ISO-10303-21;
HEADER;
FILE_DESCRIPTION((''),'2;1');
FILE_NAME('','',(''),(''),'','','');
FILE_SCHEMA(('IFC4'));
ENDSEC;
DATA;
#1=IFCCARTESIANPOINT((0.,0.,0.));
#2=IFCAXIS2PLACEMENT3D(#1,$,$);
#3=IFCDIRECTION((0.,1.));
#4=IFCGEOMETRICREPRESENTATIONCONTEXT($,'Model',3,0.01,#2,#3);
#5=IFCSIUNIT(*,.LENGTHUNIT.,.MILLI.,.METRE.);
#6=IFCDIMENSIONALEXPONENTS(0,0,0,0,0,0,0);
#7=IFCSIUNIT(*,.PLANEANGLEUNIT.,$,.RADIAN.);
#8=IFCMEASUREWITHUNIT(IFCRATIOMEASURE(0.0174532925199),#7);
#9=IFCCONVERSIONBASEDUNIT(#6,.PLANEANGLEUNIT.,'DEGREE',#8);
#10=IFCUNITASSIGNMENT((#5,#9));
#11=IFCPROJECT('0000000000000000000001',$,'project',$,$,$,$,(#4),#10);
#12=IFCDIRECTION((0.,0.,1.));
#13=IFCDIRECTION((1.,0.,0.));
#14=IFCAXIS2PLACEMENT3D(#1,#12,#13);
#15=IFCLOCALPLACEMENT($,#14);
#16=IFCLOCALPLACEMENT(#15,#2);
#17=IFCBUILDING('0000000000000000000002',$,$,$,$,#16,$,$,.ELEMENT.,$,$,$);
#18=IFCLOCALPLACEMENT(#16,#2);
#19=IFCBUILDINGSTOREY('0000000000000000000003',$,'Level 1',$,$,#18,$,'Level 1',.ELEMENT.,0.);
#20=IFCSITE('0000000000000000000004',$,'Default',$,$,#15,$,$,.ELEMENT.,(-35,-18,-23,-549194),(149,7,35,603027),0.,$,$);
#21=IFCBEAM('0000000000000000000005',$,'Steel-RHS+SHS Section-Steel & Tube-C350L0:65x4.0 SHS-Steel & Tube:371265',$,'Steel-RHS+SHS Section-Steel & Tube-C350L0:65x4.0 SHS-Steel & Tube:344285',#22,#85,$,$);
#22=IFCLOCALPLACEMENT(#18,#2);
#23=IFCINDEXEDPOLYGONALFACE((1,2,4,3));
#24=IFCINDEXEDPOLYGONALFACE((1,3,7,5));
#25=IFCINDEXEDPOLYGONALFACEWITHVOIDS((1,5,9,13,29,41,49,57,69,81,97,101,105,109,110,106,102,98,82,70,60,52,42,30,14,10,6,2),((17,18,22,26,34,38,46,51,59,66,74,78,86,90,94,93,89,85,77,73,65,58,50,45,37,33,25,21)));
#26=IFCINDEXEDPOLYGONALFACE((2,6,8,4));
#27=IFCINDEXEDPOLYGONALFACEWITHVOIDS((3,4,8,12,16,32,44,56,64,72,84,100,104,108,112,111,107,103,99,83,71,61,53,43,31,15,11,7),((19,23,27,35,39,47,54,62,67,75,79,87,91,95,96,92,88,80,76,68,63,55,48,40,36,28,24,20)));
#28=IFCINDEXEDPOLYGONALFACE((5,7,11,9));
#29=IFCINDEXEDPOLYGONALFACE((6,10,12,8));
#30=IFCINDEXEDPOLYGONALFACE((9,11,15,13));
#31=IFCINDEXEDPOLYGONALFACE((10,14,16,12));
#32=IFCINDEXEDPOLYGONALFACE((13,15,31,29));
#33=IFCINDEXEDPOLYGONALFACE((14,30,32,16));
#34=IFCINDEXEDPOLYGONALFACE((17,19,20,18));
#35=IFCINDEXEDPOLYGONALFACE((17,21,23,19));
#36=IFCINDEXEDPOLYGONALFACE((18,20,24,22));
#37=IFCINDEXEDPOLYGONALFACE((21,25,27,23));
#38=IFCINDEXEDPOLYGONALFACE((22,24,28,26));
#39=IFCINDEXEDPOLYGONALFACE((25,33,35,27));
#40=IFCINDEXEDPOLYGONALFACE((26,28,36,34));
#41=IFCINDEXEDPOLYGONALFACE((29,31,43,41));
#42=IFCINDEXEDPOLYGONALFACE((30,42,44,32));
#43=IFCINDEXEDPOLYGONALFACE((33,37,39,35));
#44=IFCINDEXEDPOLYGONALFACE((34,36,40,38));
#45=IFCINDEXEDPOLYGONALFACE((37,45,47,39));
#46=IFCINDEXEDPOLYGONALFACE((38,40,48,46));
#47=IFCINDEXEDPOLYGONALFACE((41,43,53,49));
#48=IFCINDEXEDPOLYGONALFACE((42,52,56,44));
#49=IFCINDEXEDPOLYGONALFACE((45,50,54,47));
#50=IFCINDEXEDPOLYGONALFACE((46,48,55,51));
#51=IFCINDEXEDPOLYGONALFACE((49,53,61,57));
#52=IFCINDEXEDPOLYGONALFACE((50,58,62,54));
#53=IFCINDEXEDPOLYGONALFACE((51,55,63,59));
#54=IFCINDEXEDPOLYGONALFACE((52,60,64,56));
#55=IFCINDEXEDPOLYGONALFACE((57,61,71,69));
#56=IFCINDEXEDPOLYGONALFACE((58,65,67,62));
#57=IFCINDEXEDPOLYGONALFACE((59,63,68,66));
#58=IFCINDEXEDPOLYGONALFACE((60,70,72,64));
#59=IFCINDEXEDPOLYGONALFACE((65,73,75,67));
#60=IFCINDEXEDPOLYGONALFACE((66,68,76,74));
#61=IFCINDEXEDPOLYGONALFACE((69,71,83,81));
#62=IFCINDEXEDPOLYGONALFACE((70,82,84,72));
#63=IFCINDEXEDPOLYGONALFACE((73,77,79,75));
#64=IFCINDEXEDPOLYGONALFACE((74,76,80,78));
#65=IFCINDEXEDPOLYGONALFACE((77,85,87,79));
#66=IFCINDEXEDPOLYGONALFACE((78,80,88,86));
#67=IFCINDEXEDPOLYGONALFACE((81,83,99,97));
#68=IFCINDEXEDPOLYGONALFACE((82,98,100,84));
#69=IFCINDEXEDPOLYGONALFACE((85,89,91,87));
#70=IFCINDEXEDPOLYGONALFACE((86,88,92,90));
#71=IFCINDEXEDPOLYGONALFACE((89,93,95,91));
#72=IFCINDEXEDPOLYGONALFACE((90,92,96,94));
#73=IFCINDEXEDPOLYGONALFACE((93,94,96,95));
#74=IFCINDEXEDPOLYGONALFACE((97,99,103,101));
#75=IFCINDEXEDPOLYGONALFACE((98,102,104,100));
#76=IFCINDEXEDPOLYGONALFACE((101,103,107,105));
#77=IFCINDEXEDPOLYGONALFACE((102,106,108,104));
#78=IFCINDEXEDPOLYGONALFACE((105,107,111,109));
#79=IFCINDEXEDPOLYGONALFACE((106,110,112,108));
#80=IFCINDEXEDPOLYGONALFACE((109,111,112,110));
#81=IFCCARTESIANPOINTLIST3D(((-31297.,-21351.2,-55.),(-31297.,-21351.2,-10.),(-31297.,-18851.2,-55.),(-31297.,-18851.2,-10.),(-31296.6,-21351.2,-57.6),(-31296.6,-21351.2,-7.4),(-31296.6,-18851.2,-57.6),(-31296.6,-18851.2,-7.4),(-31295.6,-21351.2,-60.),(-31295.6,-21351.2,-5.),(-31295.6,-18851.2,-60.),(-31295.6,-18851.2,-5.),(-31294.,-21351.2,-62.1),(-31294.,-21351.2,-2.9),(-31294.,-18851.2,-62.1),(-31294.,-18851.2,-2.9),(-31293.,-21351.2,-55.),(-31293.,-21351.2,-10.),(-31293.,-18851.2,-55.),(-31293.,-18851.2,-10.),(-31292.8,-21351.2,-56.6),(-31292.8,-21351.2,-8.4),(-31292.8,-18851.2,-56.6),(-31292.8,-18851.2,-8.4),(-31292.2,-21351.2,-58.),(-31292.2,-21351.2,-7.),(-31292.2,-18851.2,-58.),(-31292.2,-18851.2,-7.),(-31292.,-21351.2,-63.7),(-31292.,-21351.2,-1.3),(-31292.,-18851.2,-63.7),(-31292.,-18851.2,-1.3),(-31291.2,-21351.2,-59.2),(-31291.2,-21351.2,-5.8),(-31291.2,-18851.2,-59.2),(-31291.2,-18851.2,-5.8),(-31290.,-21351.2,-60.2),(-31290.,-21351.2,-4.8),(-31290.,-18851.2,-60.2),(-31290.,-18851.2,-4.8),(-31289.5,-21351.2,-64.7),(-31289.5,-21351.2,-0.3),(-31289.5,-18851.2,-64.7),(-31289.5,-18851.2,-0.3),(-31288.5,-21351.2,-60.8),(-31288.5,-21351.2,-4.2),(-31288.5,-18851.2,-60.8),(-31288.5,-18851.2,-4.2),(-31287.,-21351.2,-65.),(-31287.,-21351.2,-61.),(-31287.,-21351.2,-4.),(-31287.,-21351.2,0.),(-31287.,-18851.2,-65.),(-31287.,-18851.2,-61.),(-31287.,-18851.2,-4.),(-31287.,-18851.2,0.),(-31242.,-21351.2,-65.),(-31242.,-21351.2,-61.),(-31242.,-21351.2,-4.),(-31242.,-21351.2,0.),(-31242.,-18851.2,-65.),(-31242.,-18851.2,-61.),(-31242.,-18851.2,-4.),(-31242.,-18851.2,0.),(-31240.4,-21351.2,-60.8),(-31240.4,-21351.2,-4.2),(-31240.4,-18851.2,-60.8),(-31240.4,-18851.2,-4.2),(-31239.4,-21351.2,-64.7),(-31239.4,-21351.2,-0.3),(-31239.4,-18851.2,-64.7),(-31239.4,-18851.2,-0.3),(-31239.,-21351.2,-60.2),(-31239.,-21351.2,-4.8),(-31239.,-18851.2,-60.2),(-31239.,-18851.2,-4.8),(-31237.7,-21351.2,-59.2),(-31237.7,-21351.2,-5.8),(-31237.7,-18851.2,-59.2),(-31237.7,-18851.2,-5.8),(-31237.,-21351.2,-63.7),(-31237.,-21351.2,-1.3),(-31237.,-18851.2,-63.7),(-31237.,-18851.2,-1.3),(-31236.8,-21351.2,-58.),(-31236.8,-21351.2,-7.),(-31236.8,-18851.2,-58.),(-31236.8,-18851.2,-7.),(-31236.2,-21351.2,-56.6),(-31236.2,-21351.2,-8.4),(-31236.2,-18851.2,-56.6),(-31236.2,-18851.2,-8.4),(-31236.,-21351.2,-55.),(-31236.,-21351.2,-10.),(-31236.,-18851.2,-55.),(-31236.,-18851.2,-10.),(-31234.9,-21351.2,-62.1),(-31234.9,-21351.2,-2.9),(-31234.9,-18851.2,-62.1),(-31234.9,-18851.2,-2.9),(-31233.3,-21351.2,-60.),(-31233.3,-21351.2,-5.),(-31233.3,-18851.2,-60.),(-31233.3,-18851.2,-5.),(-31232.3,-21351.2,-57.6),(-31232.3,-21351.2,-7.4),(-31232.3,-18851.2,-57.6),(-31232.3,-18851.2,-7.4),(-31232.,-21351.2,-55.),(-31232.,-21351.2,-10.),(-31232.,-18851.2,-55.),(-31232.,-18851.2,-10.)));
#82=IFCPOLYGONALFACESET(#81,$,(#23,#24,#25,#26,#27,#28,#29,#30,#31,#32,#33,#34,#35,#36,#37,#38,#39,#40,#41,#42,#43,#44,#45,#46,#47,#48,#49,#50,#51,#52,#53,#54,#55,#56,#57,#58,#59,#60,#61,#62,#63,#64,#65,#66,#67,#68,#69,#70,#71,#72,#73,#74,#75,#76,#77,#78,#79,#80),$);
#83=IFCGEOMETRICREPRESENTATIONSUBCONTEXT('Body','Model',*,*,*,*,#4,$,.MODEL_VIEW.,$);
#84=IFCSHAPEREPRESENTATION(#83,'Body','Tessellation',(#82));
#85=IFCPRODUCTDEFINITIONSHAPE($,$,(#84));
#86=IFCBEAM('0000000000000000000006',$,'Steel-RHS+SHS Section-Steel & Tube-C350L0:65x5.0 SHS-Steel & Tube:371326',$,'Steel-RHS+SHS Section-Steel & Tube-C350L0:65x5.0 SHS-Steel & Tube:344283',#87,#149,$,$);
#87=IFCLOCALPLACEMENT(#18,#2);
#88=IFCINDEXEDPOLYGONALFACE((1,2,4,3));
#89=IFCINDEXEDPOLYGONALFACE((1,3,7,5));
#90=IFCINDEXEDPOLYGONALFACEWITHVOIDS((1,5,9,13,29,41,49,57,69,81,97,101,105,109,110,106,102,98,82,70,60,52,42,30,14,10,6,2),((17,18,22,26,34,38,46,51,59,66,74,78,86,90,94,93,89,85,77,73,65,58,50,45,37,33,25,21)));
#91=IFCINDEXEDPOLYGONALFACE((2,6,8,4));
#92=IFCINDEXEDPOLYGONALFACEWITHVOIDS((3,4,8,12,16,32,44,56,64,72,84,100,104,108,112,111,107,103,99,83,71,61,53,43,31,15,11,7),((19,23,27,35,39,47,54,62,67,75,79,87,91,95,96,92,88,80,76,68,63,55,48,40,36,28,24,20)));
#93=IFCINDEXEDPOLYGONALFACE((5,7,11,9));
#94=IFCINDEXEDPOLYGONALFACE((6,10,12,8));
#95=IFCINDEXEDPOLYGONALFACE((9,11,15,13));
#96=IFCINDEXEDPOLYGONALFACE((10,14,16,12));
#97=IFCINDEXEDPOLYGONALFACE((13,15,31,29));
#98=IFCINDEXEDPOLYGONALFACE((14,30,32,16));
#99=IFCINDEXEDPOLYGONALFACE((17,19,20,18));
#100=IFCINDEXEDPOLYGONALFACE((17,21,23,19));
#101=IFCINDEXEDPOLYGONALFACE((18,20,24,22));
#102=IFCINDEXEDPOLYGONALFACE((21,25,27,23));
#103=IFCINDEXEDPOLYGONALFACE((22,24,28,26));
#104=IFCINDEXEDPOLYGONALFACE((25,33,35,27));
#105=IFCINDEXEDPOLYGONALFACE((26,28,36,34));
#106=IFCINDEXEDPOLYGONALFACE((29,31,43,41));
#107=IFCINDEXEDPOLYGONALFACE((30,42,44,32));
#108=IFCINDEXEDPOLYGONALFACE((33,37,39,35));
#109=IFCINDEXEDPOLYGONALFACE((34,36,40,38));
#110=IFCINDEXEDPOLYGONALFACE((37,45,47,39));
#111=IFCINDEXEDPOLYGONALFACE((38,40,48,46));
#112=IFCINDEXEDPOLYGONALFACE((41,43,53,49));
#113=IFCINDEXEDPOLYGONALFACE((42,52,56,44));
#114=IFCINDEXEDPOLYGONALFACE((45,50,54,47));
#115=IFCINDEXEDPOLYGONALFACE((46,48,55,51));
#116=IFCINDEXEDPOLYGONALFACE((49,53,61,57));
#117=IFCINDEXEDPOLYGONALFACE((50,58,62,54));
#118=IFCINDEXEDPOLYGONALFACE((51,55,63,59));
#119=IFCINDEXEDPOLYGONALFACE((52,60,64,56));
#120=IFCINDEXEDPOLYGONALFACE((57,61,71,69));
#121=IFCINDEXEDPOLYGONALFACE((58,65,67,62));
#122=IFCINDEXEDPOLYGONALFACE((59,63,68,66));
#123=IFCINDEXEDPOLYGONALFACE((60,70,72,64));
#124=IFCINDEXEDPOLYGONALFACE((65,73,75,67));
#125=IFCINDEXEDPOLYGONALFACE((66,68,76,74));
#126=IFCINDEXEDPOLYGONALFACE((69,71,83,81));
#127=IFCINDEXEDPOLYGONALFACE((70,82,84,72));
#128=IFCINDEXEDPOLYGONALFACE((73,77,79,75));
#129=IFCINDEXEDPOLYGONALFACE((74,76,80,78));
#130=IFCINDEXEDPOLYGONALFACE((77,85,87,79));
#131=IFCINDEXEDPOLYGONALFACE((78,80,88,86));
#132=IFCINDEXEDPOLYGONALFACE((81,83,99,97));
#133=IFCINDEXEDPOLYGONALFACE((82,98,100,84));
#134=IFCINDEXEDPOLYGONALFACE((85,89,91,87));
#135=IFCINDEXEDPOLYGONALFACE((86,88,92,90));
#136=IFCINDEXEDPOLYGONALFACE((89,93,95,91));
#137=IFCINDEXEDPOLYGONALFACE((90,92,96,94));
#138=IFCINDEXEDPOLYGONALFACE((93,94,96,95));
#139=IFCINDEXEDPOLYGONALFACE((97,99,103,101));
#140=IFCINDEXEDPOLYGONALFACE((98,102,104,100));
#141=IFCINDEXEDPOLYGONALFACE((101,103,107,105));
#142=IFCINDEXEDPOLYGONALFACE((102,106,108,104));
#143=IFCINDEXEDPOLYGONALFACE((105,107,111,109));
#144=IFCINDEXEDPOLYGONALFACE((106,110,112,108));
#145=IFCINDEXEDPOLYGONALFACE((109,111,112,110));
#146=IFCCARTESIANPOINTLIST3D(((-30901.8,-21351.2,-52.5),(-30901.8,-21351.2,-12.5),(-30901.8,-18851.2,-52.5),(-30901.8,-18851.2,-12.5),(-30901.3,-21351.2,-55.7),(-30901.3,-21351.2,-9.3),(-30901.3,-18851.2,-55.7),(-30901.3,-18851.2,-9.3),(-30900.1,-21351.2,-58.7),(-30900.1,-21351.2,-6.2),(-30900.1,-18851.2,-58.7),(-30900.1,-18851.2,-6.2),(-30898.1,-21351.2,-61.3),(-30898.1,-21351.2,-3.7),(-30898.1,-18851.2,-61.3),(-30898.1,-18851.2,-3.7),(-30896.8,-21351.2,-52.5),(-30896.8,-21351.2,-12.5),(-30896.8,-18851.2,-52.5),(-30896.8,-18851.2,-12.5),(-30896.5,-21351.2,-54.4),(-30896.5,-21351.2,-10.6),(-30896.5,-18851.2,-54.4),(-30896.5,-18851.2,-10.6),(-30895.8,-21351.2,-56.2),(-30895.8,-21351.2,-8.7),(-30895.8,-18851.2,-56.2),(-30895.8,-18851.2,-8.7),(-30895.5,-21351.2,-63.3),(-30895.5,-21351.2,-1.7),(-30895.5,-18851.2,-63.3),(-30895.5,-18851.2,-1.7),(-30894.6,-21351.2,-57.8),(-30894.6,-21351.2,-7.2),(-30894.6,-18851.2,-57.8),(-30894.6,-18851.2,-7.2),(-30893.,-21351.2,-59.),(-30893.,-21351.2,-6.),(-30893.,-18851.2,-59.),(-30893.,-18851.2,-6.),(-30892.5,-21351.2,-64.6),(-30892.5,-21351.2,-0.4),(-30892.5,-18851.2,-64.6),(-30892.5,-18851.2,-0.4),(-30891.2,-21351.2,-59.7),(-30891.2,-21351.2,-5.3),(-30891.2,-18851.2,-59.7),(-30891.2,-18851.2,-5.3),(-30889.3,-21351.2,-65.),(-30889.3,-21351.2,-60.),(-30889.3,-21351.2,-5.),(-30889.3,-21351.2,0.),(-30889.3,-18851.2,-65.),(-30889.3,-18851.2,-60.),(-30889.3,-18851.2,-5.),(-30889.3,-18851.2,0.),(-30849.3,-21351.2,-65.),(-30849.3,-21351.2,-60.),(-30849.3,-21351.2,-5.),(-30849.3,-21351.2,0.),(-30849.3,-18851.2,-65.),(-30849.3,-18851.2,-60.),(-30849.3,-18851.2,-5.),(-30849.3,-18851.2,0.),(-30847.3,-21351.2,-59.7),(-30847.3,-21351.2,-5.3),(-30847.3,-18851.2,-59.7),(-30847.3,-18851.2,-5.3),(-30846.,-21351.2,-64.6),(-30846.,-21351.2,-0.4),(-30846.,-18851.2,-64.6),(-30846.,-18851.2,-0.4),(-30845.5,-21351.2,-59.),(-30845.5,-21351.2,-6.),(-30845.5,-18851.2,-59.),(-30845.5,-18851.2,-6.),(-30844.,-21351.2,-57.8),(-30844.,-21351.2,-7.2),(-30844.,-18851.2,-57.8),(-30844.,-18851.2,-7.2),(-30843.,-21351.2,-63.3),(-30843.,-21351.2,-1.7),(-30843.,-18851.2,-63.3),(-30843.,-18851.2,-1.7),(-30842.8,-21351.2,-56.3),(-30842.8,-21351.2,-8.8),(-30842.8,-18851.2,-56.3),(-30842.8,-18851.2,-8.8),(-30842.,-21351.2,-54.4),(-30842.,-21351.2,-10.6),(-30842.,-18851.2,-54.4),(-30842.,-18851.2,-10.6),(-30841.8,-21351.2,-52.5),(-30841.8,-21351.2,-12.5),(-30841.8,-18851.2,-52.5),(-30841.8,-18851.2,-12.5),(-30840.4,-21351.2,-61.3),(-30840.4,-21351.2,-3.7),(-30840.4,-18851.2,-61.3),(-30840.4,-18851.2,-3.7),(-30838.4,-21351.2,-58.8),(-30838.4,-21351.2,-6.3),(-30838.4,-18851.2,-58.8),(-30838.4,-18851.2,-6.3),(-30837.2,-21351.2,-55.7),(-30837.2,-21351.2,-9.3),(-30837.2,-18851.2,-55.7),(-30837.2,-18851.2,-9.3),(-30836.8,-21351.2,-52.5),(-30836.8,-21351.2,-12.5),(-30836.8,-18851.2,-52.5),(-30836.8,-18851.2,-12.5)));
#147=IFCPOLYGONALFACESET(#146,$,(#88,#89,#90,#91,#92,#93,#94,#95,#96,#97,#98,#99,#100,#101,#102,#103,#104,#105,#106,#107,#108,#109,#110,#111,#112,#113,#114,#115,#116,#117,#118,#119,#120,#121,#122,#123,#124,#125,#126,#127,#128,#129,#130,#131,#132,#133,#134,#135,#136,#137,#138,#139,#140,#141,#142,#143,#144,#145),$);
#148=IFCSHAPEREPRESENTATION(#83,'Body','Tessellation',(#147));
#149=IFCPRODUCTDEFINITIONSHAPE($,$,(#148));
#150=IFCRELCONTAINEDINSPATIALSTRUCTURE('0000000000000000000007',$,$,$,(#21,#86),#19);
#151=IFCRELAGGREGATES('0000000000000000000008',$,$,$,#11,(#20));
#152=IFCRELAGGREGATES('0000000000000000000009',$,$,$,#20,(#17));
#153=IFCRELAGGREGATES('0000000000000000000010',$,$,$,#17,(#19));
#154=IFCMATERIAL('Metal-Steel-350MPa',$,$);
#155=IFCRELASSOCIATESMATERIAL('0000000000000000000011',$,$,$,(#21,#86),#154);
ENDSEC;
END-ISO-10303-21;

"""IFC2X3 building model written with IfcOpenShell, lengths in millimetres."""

from ifc_helpers import new_model, entity, si_unit, converted_unit, direction, frame, frame_2d, origin, origin_with_axes, place, context, subcontext, project, spatial, polyline, circle_curve, parameter, trimmed, segment, composite_curve, outline, extrude, material, element, save


model = new_model("IFC2X3")

# Units and contexts
model_context = context("Model", 3, precision=0.01, world=origin(), true_north=direction((0.0, 1.0)))
body_context = subcontext(model_context, "Body", "Model", "MODEL_VIEW")
ifc_project = project(units=[si_unit("LENGTHUNIT", "METRE", prefix="MILLI"), converted_unit("PLANEANGLEUNIT", "DEGREE", entity("IfcRatioMeasure", 0.0174532925199), si_unit("PLANEANGLEUNIT", "RADIAN"), dimensions=[0, 0, 0, 0, 0, 0, 0])], contexts=[model_context])

# Site, building, storey
site_placement = place(None, origin_with_axes())
site = spatial("IfcSite", under=ifc_project, at=site_placement, Name="Default", CompositionType="ELEMENT", RefLatitude=(-35, -18, -23, -549194), RefLongitude=(149, 7, 35, 603027), RefElevation=0.0)
building_placement = place(site_placement, origin())
building = spatial("IfcBuilding", under=site, at=building_placement, CompositionType="ELEMENT")
storey_placement = place(building_placement, origin())
storey = spatial("IfcBuildingStorey", under=building, at=storey_placement, Name="Level 1", LongName="Level 1", CompositionType="ELEMENT", Elevation=0.0)

# Beams
ifc_material = material(Name="Metal-Steel-350MPa")
beam_1_placement = place(storey_placement, frame((-31264.5, -18851.2, 0.0), z_axis=(0.0, 0.0, 1.0), x_axis=(0.0, -1.0, 0.0)))
element("IfcBeam", 1, at=beam_1_placement, inside=storey, material=ifc_material, Name="Steel-RHS+SHS Section-Steel & Tube-C350L0:65x4.0 SHS-Steel & Tube:371265", ObjectType="Steel-RHS+SHS Section-Steel & Tube-C350L0:65x4.0 SHS-Steel & Tube:344285", context=body_context, shape_type="SweptSolid", body=[
    extrude(outline(composite_curve([segment(trimmed(circle_curve(frame_2d((-22.5, -22.5), x_axis=(1.0, 0.0)), 10.0), [parameter(180.0)], [parameter(270.0)], True, "PARAMETER"), True, "CONTINUOUS"), segment(polyline([(-22.5, -32.5), (22.5, -32.5)]), True, "CONTINUOUS"), segment(trimmed(circle_curve(frame_2d((22.5, -22.5), x_axis=(1.0, 0.0)), 10.0), [parameter(270.0)], [parameter(0.0)], True, "PARAMETER"), True, "CONTINUOUS"), segment(polyline([(32.5, -22.5), (32.5, 22.5)]), True, "CONTINUOUS"), segment(trimmed(circle_curve(frame_2d((22.5, 22.5), x_axis=(1.0, 0.0)), 10.0), [parameter(0.0)], [parameter(90.0)], True, "PARAMETER"), True, "CONTINUOUS"), segment(polyline([(22.5, 32.5), (-22.5, 32.5)]), True, "CONTINUOUS"), segment(trimmed(circle_curve(frame_2d((-22.5, 22.5), x_axis=(1.0, 0.0)), 10.0), [parameter(90.0)], [parameter(180.0)], True, "PARAMETER"), True, "CONTINUOUS"), segment(polyline([(-32.5, 22.5), (-32.5, -22.5)]), True, "CONTINUOUS")], self_intersect=False), holes=[composite_curve([segment(polyline([(22.5, -28.5), (-22.5, -28.5)]), True, "CONTINUOUS"), segment(trimmed(circle_curve(frame_2d((-22.5, -22.5), x_axis=(1.0, 0.0)), 6.0), [parameter(180.0)], [parameter(270.0)], True, "PARAMETER"), False, "CONTINUOUS"), segment(polyline([(-28.5, -22.5), (-28.5, 22.5)]), True, "CONTINUOUS"), segment(trimmed(circle_curve(frame_2d((-22.5, 22.5), x_axis=(1.0, 0.0)), 6.0), [parameter(90.0)], [parameter(180.0)], True, "PARAMETER"), False, "CONTINUOUS"), segment(polyline([(-22.5, 28.5), (22.5, 28.5)]), True, "CONTINUOUS"), segment(trimmed(circle_curve(frame_2d((22.5, 22.5), x_axis=(1.0, 0.0)), 6.0), [parameter(360.0)], [parameter(90.0)], True, "PARAMETER"), False, "CONTINUOUS"), segment(polyline([(28.5, 22.5), (28.5, -22.5)]), True, "CONTINUOUS"), segment(trimmed(circle_curve(frame_2d((22.5, -22.5), x_axis=(1.0, 0.0)), 6.0), [parameter(270.0)], [parameter(0.0)], True, "PARAMETER"), False, "CONTINUOUS")], self_intersect=False)]), frame((0.0, 0.0, -32.5), z_axis=(1.0, 0.0, 0.0), x_axis=(0.0, -1.0, 0.0)), (0.0, 0.0, 1.0), 2500.0),
])
beam_2_placement = place(storey_placement, frame((-30869.3, -18851.2, 0.0), z_axis=(0.0, 0.0, 1.0), x_axis=(0.0, -1.0, 0.0)))
element("IfcBeam", 2, at=beam_2_placement, inside=storey, material=ifc_material, Name="Steel-RHS+SHS Section-Steel & Tube-C350L0:65x5.0 SHS-Steel & Tube:371326", ObjectType="Steel-RHS+SHS Section-Steel & Tube-C350L0:65x5.0 SHS-Steel & Tube:344283", context=body_context, shape_type="SweptSolid", body=[
    extrude(outline(composite_curve([segment(trimmed(circle_curve(frame_2d((-20.0, -20.0), x_axis=(1.0, 0.0)), 12.5), [parameter(180.0)], [parameter(270.0)], True, "PARAMETER"), True, "CONTINUOUS"), segment(polyline([(-20.0, -32.5), (20.0, -32.5)]), True, "CONTINUOUS"), segment(trimmed(circle_curve(frame_2d((20.0, -20.0), x_axis=(1.0, 0.0)), 12.5), [parameter(270.0)], [parameter(0.0)], True, "PARAMETER"), True, "CONTINUOUS"), segment(polyline([(32.5, -20.0), (32.5, 20.0)]), True, "CONTINUOUS"), segment(trimmed(circle_curve(frame_2d((20.0, 20.0), x_axis=(1.0, 0.0)), 12.5), [parameter(0.0)], [parameter(90.0)], True, "PARAMETER"), True, "CONTINUOUS"), segment(polyline([(20.0, 32.5), (-20.0, 32.5)]), True, "CONTINUOUS"), segment(trimmed(circle_curve(frame_2d((-20.0, 20.0), x_axis=(1.0, 0.0)), 12.5), [parameter(90.0)], [parameter(180.0)], True, "PARAMETER"), True, "CONTINUOUS"), segment(polyline([(-32.5, 20.0), (-32.5, -20.0)]), True, "CONTINUOUS")], self_intersect=False), holes=[composite_curve([segment(polyline([(20.0, -27.5), (-20.0, -27.5)]), True, "CONTINUOUS"), segment(trimmed(circle_curve(frame_2d((-20.0, -20.0), x_axis=(1.0, 0.0)), 7.5), [parameter(180.0)], [parameter(270.0)], True, "PARAMETER"), False, "CONTINUOUS"), segment(polyline([(-27.5, -20.0), (-27.5, 20.0)]), True, "CONTINUOUS"), segment(trimmed(circle_curve(frame_2d((-20.0, 20.0), x_axis=(1.0, 0.0)), 7.5), [parameter(90.0)], [parameter(180.0)], True, "PARAMETER"), False, "CONTINUOUS"), segment(polyline([(-20.0, 27.5), (20.0, 27.5)]), True, "CONTINUOUS"), segment(trimmed(circle_curve(frame_2d((20.0, 20.0), x_axis=(1.0, 0.0)), 7.5), [parameter(360.0)], [parameter(90.0)], True, "PARAMETER"), False, "CONTINUOUS"), segment(polyline([(27.5, 20.0), (27.5, -20.0)]), True, "CONTINUOUS"), segment(trimmed(circle_curve(frame_2d((20.0, -20.0), x_axis=(1.0, 0.0)), 7.5), [parameter(270.0)], [parameter(360.0)], True, "PARAMETER"), False, "CONTINUOUS")], self_intersect=False)]), frame((0.0, 0.0, -32.5), z_axis=(1.0, 0.0, 0.0), x_axis=(0.0, -1.0, 0.0)), (0.0, 0.0, 1.0), 2500.0),
])

save(model, "model.ifc")
